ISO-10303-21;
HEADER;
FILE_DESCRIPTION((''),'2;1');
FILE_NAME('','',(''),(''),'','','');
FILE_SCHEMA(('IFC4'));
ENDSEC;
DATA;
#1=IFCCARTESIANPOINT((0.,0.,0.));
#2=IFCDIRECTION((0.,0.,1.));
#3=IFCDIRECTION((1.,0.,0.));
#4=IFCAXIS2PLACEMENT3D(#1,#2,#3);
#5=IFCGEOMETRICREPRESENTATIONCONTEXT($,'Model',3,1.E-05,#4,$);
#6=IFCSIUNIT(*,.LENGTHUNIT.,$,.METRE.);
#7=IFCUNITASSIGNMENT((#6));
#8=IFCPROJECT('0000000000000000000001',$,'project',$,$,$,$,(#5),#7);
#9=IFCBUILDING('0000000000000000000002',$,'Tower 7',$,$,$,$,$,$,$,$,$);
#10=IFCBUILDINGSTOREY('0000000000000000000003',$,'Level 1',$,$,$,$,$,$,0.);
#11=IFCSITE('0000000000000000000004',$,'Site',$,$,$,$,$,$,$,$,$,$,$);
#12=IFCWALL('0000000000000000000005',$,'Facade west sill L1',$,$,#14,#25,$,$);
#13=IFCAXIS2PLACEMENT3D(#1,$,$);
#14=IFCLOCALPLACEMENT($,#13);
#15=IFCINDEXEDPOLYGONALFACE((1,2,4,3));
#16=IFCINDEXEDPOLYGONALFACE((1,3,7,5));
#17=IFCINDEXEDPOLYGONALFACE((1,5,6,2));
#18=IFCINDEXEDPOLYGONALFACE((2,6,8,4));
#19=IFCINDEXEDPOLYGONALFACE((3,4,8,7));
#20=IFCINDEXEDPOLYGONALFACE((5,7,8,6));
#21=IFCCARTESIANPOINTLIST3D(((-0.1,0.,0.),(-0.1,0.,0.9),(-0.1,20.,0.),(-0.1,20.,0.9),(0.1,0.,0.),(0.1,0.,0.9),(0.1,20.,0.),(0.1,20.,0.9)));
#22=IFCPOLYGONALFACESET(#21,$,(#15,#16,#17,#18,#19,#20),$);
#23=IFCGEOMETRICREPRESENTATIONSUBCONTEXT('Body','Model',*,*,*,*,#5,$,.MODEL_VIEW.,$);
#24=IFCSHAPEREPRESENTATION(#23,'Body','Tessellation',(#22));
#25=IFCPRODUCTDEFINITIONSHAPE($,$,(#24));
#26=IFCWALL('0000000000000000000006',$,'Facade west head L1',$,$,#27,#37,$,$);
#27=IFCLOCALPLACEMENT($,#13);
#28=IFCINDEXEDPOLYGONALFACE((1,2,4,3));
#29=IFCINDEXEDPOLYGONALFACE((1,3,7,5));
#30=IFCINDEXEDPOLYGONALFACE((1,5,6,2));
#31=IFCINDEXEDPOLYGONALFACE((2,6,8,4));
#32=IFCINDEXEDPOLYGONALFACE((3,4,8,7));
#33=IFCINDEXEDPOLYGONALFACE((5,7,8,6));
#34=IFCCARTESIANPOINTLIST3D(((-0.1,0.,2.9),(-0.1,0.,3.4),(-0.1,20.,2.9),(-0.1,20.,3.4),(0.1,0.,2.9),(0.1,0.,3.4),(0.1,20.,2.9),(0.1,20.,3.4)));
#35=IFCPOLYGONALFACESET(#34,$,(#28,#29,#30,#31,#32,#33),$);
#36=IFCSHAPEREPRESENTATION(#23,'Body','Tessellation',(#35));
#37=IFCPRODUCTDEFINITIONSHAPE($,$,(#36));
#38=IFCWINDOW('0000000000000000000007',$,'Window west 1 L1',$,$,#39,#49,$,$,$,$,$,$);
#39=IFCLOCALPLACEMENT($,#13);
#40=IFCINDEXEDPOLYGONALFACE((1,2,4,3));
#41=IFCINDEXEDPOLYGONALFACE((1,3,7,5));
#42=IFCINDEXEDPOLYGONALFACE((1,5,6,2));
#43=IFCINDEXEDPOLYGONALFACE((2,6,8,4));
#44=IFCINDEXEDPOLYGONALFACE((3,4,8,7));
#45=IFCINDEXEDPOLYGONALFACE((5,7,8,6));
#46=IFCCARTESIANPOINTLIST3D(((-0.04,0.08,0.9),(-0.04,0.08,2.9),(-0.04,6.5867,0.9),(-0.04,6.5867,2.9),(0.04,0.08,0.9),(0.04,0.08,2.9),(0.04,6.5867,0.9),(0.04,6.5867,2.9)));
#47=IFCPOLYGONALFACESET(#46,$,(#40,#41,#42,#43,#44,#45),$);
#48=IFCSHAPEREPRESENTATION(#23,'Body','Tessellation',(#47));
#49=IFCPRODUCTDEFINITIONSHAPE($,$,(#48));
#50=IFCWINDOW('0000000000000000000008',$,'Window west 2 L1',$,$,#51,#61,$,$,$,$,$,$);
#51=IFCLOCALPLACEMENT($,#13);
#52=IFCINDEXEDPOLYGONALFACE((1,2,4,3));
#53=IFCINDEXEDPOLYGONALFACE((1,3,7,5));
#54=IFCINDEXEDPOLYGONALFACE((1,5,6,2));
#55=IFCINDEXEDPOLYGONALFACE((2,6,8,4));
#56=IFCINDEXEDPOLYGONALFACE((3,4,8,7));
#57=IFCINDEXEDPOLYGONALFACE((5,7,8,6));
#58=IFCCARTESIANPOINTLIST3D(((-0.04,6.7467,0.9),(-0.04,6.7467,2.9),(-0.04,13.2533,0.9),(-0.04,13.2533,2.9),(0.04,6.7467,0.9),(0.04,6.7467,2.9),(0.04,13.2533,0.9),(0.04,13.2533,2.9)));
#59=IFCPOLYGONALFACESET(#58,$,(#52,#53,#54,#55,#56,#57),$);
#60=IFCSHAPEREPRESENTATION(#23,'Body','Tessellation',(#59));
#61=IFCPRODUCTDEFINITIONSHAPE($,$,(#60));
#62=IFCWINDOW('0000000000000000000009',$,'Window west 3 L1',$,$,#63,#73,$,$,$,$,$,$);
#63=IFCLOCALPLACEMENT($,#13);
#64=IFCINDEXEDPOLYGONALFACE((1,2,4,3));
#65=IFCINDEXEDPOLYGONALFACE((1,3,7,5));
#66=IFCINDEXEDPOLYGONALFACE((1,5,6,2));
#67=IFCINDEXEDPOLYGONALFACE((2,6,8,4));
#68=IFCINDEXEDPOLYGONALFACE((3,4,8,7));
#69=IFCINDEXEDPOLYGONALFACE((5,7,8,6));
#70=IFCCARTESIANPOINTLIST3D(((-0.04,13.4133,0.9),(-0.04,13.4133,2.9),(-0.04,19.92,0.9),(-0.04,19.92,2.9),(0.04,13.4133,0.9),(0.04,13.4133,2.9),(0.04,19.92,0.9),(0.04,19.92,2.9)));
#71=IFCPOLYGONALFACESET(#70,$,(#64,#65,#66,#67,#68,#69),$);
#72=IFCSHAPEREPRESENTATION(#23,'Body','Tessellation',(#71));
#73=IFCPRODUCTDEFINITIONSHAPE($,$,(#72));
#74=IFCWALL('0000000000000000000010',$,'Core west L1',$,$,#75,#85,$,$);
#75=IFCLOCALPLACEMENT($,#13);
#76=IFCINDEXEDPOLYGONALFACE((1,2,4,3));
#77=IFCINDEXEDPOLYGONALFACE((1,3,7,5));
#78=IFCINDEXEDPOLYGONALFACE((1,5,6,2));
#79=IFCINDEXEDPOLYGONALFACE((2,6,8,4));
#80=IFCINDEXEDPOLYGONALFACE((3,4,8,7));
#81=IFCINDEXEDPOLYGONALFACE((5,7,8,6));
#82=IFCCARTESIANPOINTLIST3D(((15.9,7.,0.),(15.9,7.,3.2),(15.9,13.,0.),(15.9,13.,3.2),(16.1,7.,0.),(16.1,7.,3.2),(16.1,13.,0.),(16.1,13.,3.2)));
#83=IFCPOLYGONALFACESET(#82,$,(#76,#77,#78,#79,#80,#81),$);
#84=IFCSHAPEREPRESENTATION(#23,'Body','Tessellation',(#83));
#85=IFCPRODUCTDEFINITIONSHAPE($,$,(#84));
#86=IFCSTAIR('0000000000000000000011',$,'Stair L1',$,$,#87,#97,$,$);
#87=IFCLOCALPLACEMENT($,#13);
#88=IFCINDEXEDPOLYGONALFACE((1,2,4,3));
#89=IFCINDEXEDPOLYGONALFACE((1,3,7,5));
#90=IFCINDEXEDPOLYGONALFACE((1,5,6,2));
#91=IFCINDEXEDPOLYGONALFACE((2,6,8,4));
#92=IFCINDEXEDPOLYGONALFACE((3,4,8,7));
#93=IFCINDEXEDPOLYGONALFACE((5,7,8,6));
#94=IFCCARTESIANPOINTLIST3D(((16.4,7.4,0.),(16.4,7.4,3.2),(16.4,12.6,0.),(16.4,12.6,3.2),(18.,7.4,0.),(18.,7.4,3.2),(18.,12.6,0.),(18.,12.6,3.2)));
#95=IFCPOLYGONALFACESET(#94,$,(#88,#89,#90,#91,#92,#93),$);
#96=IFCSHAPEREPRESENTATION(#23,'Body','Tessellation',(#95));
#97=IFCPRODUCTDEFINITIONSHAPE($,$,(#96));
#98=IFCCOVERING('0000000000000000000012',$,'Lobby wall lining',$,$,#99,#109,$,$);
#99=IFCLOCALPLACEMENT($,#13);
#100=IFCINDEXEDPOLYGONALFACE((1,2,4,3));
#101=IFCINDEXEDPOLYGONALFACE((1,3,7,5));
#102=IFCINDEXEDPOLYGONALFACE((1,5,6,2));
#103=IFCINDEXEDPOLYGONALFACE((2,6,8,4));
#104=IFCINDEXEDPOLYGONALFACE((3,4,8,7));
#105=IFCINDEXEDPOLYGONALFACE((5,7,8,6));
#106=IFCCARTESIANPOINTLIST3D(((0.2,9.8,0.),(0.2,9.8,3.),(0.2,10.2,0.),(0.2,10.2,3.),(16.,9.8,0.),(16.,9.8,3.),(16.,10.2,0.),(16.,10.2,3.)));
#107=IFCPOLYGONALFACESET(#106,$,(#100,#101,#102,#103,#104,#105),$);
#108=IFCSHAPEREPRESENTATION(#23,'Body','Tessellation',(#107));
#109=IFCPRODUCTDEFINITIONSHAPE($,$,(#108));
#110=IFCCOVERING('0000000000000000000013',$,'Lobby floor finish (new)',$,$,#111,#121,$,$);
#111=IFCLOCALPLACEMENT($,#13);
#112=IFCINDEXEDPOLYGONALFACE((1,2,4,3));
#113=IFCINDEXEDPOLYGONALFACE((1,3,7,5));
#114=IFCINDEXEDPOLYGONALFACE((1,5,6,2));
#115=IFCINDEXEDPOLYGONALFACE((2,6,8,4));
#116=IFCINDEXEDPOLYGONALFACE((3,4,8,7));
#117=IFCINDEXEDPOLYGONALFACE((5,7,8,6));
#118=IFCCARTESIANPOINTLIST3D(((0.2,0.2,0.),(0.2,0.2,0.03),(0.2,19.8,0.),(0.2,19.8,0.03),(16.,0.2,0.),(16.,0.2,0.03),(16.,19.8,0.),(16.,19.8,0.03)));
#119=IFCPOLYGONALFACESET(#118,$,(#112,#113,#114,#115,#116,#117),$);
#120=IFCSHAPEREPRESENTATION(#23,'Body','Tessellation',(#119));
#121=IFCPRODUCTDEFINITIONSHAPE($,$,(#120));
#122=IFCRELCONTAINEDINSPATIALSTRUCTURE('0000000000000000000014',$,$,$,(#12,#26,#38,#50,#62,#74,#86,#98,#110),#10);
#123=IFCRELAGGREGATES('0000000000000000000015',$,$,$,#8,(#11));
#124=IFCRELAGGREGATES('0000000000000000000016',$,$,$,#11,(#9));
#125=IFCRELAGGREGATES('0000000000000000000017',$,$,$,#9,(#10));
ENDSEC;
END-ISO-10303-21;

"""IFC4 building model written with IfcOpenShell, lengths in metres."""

from ifc_helpers import new_model, si_unit, frame, origin, origin_with_axes, origin_2d, place, context, subcontext, project, spatial, rectangle, extrude, element, save


model = new_model("IFC4")

# Units and contexts
model_context = context("Model", 3, precision=1e-05, world=origin_with_axes())
body_context = subcontext(model_context, "Body", "Model", "MODEL_VIEW")
ifc_project = project(units=[si_unit("LENGTHUNIT", "METRE")], contexts=[model_context])

# Site, building, storey
site = spatial("IfcSite", under=ifc_project, Name="Site")
building = spatial("IfcBuilding", under=site, Name="Tower 7")
storey = spatial("IfcBuildingStorey", under=building, Name="Level 1", Elevation=0.0)

# Walls
wall_1_placement = place(None, frame((0.0, 10.0, 0.0), z_axis=(0.0, 0.0, 1.0), x_axis=(1.0, 0.0, 0.0)))
element("IfcWall", 1, at=wall_1_placement, inside=storey, Name="Facade west sill L1", context=body_context, shape_type="SweptSolid", body=[
    extrude(rectangle(XDim=0.2, YDim=20.0, at=origin_2d()), origin(), (0.0, 0.0, 1.0), 0.9),
])
wall_2_placement = place(None, frame((0.0, 10.0, 2.9), z_axis=(0.0, 0.0, 1.0), x_axis=(1.0, 0.0, 0.0)))
element("IfcWall", 2, at=wall_2_placement, inside=storey, Name="Facade west head L1", context=body_context, shape_type="SweptSolid", body=[
    extrude(rectangle(XDim=0.2, YDim=20.0, at=origin_2d()), origin(), (0.0, 0.0, 1.0), 0.5),
])

# Windows
for number, where, z_axis, x_axis, name in (
    (3, (0.0, 3.3333, 0.9), (0.0, 0.0, 1.0), (1.0, 0.0, 0.0), "Window west 1 L1"),
    (4, (0.0, 10.0, 0.9), (0.0, 0.0, 1.0), (1.0, 0.0, 0.0), "Window west 2 L1"),
):
    element("IfcWindow", number, at=place(None, frame(where, z_axis=z_axis, x_axis=x_axis)), inside=storey, Name=name, context=body_context, shape_type="SweptSolid", body=[
        extrude(rectangle(XDim=0.08, YDim=6.5067, at=origin_2d()), origin(), (0.0, 0.0, 1.0), 2.0),
    ])
window_1_placement = place(None, frame((0.0, 16.6667, 0.9), z_axis=(0.0, 0.0, 1.0), x_axis=(1.0, 0.0, 0.0)))
element("IfcWindow", 5, at=window_1_placement, inside=storey, Name="Window west 3 L1", context=body_context, shape_type="SweptSolid", body=[
    extrude(rectangle(XDim=0.08, YDim=6.5067, at=origin_2d()), origin(), (0.0, 0.0, 1.0), 2.0),
])

# Wall
wall_3_placement = place(None, frame((16.0, 10.0, 0.0), z_axis=(0.0, 0.0, 1.0), x_axis=(1.0, 0.0, 0.0)))
element("IfcWall", 6, at=wall_3_placement, inside=storey, Name="Core west L1", context=body_context, shape_type="SweptSolid", body=[
    extrude(rectangle(XDim=0.2, YDim=6.0, at=origin_2d()), origin(), (0.0, 0.0, 1.0), 3.2),
])

# Stair
stair_placement = place(None, frame((17.2, 10.0, 0.0), z_axis=(0.0, 0.0, 1.0), x_axis=(1.0, 0.0, 0.0)))
element("IfcStair", 7, at=stair_placement, inside=storey, Name="Stair L1", context=body_context, shape_type="SweptSolid", body=[
    extrude(rectangle(XDim=1.6, YDim=5.2, at=origin_2d()), origin(), (0.0, 0.0, 1.0), 3.2),
])

# Coverings
covering_1_placement = place(None, frame((8.1, 10.0, 0.0), z_axis=(0.0, 0.0, 1.0), x_axis=(1.0, 0.0, 0.0)))
element("IfcCovering", 8, at=covering_1_placement, inside=storey, Name="Lobby wall lining", context=body_context, shape_type="SweptSolid", body=[
    extrude(rectangle(XDim=15.8, YDim=0.4, at=origin_2d()), origin(), (0.0, 0.0, 1.0), 3.0),
])
covering_2_placement = place(None, frame((8.1, 10.0, 0.0), z_axis=(0.0, 0.0, 1.0), x_axis=(1.0, 0.0, 0.0)))
element("IfcCovering", 9, at=covering_2_placement, inside=storey, Name="Lobby floor finish (new)", context=body_context, shape_type="SweptSolid", body=[
    extrude(rectangle(XDim=15.8, YDim=19.6, at=origin_2d()), origin(), (0.0, 0.0, 1.0), 0.03),
])

save(model, "model.ifc")
